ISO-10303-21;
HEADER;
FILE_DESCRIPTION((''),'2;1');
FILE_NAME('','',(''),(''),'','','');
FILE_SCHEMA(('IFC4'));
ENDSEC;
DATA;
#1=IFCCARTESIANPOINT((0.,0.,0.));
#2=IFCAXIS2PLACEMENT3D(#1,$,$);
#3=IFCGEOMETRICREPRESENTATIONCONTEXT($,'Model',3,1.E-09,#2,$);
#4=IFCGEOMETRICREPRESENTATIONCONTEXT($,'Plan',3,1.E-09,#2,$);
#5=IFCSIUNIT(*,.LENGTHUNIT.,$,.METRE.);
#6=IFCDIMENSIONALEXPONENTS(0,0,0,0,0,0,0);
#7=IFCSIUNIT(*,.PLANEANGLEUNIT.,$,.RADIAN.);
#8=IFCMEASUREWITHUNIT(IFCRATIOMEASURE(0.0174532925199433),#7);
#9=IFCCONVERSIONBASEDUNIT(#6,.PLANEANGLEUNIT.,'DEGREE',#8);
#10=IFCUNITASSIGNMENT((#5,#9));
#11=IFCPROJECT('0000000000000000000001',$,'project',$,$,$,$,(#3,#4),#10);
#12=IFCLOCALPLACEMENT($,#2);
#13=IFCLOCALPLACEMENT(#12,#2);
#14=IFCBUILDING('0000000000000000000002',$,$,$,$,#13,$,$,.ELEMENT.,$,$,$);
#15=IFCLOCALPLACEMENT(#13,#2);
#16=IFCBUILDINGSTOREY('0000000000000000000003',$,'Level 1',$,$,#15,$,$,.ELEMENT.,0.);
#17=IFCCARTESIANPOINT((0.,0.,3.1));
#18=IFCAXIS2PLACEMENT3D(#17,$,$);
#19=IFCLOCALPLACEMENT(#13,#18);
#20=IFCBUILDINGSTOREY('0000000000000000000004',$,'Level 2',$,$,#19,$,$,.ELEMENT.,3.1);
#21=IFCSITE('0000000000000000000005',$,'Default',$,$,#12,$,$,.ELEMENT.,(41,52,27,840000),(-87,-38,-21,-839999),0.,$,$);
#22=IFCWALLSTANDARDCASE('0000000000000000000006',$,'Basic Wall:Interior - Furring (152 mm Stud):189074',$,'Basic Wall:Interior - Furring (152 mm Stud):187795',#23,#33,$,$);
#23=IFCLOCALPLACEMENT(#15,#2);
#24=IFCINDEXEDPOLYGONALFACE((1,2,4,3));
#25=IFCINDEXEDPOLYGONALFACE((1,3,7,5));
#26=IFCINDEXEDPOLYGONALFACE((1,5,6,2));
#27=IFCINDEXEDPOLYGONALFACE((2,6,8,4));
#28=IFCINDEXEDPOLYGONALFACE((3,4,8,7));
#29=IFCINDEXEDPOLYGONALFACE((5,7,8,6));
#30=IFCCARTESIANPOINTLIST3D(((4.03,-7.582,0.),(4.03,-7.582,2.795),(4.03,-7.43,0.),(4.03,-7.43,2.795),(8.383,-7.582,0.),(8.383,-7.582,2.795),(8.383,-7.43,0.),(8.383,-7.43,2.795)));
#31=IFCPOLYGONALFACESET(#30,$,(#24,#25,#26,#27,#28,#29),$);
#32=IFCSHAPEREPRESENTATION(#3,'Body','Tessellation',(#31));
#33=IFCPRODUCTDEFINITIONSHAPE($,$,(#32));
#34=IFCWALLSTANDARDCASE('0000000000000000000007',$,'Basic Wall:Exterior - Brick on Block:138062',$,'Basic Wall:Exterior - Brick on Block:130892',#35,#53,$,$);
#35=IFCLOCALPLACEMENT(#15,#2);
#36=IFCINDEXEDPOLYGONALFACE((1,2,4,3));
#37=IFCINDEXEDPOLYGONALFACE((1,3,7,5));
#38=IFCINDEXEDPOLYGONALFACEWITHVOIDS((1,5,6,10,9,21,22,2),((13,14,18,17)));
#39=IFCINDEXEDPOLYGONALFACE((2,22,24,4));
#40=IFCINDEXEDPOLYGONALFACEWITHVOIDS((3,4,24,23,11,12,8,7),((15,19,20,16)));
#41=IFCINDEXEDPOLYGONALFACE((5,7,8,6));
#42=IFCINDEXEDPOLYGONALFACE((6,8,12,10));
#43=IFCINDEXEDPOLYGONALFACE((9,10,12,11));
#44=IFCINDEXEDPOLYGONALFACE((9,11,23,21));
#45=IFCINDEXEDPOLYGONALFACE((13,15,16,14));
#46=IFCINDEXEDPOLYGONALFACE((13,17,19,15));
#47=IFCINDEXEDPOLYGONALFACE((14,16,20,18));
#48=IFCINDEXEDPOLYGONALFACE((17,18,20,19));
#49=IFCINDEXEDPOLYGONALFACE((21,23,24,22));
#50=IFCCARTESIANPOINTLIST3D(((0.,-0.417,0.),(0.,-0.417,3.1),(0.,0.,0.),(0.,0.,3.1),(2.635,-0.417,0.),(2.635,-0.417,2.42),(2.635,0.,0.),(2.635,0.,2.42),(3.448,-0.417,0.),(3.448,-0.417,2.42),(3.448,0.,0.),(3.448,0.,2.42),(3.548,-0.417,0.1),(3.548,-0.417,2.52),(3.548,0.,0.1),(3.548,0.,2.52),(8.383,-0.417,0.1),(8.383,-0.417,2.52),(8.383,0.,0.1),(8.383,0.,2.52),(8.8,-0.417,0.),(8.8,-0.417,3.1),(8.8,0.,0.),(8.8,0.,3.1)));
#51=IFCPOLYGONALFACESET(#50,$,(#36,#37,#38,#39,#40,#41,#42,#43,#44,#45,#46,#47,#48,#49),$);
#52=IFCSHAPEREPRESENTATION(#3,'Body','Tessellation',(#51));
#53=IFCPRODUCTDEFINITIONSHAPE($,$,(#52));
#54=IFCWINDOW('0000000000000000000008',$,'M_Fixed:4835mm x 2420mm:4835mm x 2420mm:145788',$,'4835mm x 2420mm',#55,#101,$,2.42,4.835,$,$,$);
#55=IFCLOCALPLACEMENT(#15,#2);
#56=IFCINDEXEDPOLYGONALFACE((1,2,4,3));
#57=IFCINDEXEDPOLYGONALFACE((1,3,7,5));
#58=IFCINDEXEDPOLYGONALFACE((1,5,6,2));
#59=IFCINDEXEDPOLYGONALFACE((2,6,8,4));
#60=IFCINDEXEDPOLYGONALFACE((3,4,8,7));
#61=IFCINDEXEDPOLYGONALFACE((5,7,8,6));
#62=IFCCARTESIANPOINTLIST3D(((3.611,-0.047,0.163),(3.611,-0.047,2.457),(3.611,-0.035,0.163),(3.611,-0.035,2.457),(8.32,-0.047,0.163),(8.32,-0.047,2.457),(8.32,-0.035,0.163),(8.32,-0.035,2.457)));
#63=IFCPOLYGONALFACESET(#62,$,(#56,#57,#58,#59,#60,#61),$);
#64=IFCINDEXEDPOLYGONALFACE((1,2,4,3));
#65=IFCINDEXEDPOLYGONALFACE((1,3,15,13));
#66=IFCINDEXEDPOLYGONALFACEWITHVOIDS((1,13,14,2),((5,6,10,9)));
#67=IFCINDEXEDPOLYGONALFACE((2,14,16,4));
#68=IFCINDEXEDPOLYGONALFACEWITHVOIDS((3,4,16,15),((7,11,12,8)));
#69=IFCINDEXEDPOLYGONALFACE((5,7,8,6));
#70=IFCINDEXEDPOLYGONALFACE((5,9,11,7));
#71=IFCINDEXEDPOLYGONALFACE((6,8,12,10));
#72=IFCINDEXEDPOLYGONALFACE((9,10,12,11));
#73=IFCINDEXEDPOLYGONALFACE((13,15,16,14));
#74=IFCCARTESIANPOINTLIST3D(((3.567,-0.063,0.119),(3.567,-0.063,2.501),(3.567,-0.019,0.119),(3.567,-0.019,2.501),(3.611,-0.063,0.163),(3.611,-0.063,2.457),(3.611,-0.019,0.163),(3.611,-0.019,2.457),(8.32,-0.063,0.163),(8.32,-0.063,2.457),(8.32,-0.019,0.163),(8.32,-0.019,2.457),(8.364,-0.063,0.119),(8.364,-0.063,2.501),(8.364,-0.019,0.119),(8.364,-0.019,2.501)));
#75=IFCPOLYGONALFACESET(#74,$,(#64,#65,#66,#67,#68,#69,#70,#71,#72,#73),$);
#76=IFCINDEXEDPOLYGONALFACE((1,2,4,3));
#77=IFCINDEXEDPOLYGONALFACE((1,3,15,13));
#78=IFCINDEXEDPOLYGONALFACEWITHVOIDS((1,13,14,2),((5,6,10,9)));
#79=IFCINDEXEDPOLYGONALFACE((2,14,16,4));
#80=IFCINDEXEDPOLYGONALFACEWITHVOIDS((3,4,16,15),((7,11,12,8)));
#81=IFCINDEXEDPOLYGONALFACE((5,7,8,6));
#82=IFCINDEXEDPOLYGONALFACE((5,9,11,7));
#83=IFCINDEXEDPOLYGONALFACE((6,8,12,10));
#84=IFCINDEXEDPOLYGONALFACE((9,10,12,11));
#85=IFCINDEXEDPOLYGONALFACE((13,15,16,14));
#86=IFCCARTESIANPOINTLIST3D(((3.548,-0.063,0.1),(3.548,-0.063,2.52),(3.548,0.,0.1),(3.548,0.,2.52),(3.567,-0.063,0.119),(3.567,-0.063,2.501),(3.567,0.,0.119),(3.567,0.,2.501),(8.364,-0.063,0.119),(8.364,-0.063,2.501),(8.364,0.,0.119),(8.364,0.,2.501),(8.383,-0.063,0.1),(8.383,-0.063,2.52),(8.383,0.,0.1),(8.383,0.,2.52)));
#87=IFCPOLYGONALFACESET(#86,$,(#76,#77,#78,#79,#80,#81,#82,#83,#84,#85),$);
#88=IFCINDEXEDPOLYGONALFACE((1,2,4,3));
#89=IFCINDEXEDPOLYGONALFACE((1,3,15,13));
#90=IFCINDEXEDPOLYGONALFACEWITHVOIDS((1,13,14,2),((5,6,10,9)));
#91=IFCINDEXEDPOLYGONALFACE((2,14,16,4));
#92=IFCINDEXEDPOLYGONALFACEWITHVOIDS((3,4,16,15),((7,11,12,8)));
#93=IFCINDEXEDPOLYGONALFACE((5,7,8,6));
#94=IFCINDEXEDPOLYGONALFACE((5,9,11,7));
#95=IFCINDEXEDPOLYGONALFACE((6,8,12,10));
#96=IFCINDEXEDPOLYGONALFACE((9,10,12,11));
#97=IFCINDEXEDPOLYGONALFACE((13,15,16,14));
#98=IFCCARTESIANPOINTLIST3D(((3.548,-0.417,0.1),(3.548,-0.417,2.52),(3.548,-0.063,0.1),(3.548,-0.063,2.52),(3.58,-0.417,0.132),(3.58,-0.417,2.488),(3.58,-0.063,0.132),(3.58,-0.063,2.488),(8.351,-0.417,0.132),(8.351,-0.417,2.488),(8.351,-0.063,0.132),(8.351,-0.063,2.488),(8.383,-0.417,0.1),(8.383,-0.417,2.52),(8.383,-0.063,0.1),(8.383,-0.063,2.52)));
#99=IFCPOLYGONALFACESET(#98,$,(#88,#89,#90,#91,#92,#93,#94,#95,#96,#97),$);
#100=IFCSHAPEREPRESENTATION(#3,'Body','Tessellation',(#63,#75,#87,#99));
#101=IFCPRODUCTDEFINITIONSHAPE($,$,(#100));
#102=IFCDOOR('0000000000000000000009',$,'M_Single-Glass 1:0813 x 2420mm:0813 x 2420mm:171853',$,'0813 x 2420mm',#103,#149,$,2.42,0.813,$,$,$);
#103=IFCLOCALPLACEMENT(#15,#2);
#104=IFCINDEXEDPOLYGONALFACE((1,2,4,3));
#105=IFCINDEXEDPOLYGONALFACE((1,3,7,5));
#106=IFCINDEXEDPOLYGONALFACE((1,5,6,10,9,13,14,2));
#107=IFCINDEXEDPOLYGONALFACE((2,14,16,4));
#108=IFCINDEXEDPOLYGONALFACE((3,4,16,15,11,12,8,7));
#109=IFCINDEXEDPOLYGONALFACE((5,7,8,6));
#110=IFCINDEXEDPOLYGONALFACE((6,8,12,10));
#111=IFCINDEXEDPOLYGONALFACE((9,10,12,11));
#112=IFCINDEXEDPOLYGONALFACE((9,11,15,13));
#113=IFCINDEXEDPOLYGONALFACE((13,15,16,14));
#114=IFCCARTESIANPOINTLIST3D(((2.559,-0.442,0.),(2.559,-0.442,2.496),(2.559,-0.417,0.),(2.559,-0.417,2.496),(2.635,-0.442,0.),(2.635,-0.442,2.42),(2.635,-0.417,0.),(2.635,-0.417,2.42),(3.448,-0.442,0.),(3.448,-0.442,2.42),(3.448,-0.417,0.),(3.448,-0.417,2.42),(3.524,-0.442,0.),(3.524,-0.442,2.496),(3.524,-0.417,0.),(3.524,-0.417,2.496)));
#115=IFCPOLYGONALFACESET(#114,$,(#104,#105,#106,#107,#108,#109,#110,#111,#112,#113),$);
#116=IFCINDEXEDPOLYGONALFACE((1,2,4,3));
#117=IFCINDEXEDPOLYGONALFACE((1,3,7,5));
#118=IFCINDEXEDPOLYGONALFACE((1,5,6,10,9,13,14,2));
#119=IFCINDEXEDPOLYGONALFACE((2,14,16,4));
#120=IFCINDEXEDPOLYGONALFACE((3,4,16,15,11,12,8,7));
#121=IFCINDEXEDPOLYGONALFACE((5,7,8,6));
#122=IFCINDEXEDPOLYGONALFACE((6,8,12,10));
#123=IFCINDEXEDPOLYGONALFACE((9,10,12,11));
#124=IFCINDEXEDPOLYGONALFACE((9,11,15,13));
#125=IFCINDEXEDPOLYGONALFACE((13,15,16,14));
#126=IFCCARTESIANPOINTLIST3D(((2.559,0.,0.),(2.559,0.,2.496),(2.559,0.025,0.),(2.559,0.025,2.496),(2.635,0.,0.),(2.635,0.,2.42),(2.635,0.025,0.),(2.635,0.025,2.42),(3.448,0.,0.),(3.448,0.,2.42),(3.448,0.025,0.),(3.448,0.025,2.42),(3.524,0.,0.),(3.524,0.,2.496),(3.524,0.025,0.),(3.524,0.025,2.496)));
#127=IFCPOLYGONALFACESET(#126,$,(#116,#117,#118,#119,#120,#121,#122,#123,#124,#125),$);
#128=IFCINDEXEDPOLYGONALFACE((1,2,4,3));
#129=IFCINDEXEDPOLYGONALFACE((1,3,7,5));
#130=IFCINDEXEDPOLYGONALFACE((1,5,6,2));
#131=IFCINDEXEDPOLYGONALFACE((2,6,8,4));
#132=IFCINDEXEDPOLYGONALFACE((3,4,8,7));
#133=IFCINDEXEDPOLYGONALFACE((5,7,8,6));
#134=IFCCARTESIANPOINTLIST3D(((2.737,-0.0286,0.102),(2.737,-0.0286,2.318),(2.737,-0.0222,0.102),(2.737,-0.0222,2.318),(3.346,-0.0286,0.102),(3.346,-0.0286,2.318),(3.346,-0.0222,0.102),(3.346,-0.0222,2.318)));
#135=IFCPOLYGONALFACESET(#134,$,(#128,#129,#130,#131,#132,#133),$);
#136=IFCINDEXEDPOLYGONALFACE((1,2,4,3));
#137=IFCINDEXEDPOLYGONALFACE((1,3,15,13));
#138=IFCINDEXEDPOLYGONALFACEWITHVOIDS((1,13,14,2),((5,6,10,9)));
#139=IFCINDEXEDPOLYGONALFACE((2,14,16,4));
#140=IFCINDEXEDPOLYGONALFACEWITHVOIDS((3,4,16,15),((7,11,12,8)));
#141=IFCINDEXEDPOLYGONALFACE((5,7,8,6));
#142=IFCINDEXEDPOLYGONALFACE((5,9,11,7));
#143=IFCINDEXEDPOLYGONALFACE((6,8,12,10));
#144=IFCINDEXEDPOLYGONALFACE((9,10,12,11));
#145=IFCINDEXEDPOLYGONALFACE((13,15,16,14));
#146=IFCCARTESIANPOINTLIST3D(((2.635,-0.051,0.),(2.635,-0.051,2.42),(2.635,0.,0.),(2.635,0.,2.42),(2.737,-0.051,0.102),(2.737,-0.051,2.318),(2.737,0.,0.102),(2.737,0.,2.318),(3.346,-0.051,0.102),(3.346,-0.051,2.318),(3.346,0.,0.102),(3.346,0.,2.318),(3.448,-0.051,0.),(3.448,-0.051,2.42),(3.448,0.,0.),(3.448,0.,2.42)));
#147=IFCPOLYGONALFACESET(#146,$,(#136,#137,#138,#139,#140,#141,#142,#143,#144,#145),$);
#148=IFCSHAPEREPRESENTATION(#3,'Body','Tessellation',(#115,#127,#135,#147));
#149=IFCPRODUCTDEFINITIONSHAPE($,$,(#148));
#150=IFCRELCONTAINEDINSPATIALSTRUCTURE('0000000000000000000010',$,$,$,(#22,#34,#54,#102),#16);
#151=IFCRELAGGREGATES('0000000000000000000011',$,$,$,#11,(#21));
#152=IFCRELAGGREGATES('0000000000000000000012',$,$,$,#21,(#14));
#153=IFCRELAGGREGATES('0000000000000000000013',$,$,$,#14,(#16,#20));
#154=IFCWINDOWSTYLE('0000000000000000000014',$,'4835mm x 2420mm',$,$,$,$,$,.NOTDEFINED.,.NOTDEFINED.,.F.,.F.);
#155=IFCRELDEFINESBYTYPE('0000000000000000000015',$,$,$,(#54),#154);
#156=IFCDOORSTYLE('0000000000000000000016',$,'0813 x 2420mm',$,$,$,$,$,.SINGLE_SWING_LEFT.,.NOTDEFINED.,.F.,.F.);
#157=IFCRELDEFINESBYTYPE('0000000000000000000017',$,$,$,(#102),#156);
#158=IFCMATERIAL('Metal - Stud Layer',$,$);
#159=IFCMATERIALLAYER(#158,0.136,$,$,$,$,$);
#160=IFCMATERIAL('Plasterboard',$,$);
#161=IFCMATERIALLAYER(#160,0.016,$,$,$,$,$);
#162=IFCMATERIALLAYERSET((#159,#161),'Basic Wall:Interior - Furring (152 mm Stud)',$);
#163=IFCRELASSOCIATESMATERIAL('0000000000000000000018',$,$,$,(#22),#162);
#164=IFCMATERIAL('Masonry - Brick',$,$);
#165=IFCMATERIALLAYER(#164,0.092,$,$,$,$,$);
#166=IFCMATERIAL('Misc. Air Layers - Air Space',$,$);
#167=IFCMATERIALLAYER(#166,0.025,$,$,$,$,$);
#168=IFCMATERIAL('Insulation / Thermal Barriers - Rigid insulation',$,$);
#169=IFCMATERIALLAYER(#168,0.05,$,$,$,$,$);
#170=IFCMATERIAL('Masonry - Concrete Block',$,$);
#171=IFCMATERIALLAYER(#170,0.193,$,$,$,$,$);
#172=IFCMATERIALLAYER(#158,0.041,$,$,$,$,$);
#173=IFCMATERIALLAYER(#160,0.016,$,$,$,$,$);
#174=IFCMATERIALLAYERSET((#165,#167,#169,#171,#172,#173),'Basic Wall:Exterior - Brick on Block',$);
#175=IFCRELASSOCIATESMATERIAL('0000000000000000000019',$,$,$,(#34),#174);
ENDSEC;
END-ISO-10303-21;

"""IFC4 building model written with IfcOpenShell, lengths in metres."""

from ifc_helpers import new_model, entity, si_unit, converted_unit, frame, frame_2d, origin, origin_2d_with_axis, place, context, project, spatial, polyline, rectangle, outline, extrude, clip, bounded_halfspace, source, transform, mapped, material, layer, layer_set, layer_usage, type_object, type_shapes, element, fill, save


model = new_model("IFC4")

# Units and contexts
model_context = context("Model", 3, precision=1e-09, world=origin())
plan_context = context("Plan", 3, precision=1e-09, world=origin())
ifc_project = project(units=[si_unit("LENGTHUNIT", "METRE"), converted_unit("PLANEANGLEUNIT", "DEGREE", entity("IfcRatioMeasure", 0.0174532925199433), si_unit("PLANEANGLEUNIT", "RADIAN"), dimensions=[0, 0, 0, 0, 0, 0, 0])], contexts=[model_context, plan_context])

# Site, building, storey
site_placement = place(None, origin())
site = spatial("IfcSite", under=ifc_project, at=site_placement, Name="Default", CompositionType="ELEMENT", RefLatitude=(41, 52, 27, 840000), RefLongitude=(-87, -38, -21, -839999), RefElevation=0.0)
building_placement = place(site_placement, origin())
building = spatial("IfcBuilding", under=site, at=building_placement, CompositionType="ELEMENT")
storey_1_placement = place(building_placement, origin())
storey_1 = spatial("IfcBuildingStorey", under=building, at=storey_1_placement, Name="Level 1", CompositionType="ELEMENT", Elevation=0.0)

# Wall
ifc_material_1 = material(Name="Metal - Stud Layer")
ifc_layer_1 = layer(ifc_material_1, 0.136)
ifc_material_2 = material(Name="Plasterboard")
ifc_layer_2 = layer(ifc_material_2, 0.016)
ifc_layer_set_1 = layer_set([ifc_layer_1, ifc_layer_2], Name="Basic Wall:Interior - Furring (152 mm Stud)")
ifc_layer_usage_1 = layer_usage(ifc_layer_set_1, "AXIS2", "NEGATIVE", 0.076)
wall_1_placement = place(storey_1_placement, frame((8.383, -7.506, 0.0), z_axis=(0.0, 0.0, 1.0), x_axis=(-1.0, 0.0, 0.0)))
element("IfcWallStandardCase", 1, at=wall_1_placement, inside=storey_1, material=ifc_layer_usage_1, Name="Basic Wall:Interior - Furring (152 mm Stud):189074", ObjectType="Basic Wall:Interior - Furring (152 mm Stud):187795", context=model_context, shape_type="Clipping", body=[
    clip(extrude(rectangle(XDim=4.353, YDim=0.152, at=frame_2d((2.1765, 0.0), x_axis=(-1.0, 0.0))), origin(), (0.0, 0.0, 1.0), 2.795), bounded_halfspace(frame((0.0, -0.076, 2.795), z_axis=(0.0, 0.0, -1.0), x_axis=(0.0, 1.0, 0.0)), True, frame((0.0, -0.076, 2.795)), polyline([(0.0, 0.0), (3.708, 0.0), (3.708, 0.152), (0.0, 0.152), (0.0, 0.0)]))),
])
ifc_material_3 = material(Name="Masonry - Concrete Block")
ifc_material_4 = material(Name="Misc. Air Layers - Air Space")

# Wall, openings, window, door
ifc_material_5 = material(Name="Masonry - Brick")
ifc_layer_3 = layer(ifc_material_5, 0.092)
ifc_layer_4 = layer(ifc_material_4, 0.025)
ifc_material_6 = material(Name="Insulation / Thermal Barriers - Rigid insulation")
ifc_layer_5 = layer(ifc_material_6, 0.05)
ifc_layer_6 = layer(ifc_material_3, 0.193)
ifc_layer_7 = layer(ifc_material_1, 0.041)
ifc_layer_8 = layer(ifc_material_2, 0.016)
ifc_layer_set_2 = layer_set([ifc_layer_3, ifc_layer_4, ifc_layer_5, ifc_layer_6, ifc_layer_7, ifc_layer_8], Name="Basic Wall:Exterior - Brick on Block")
ifc_layer_usage_2 = layer_usage(ifc_layer_set_2, "AXIS2", "NEGATIVE", 0.2085)
wall_2_placement = place(storey_1_placement, frame((0.0, -0.2085, 0.0)))
wall_2 = element("IfcWallStandardCase", 2, at=wall_2_placement, inside=storey_1, material=ifc_layer_usage_2, Name="Basic Wall:Exterior - Brick on Block:138062", ObjectType="Basic Wall:Exterior - Brick on Block:130892", context=model_context, shape_type="SweptSolid", body=[
    extrude(rectangle(XDim=8.8, YDim=0.417, at=frame_2d((4.4, 0.0), x_axis=(-1.0, 0.0))), origin(), (0.0, 0.0, 1.0), 3.1),
])
opening_1_placement = place(wall_2_placement, frame((2.635, -0.2085, 0.0)))
opening_1 = element("IfcOpeningElement", 3, at=opening_1_placement, cuts=wall_2, ObjectType="Opening", context=model_context, shape_type="SweptSolid", body=[
    extrude(rectangle(XDim=0.813, YDim=2.42, at=frame_2d((1.21, 0.4065), x_axis=(0.0, -1.0))), frame((0.0, 0.0, 0.0), z_axis=(0.0, 1.0, 0.0), x_axis=(0.0, 0.0, 1.0)), (0.0, 0.0, 1.0), 0.417),
])
opening_2_placement = place(wall_2_placement, frame((3.548, -0.2085, 0.1)))
opening_2 = element("IfcOpeningElement", 4, at=opening_2_placement, cuts=wall_2, ObjectType="Opening", context=model_context, shape_type="SweptSolid", body=[
    extrude(rectangle(XDim=2.42, YDim=4.835, at=frame_2d((1.21, 2.4175), x_axis=(1.0, 0.0))), frame((0.0, 0.0, 0.0), z_axis=(0.0, 1.0, 0.0), x_axis=(0.0, 0.0, 1.0)), (0.0, 0.0, 1.0), 0.417),
])
window_style_1 = type_object("IfcWindowStyle", Name="4835mm x 2420mm", ConstructionType="NOTDEFINED", OperationType="NOTDEFINED", ParameterTakesPrecedence=False, Sizeable=False)
shared_shape_1 = source(origin(), model_context, "Body", "SweptSolid", [
    extrude(rectangle(XDim=0.012, YDim=4.709, at=origin_2d_with_axis()), frame((2.4175, 0.376, 0.063), z_axis=(0.0, 0.0, 1.0), x_axis=(0.0, -1.0, 0.0)), (0.0, 0.0, 1.0), 2.294),
    extrude(outline(polyline([(-2.3985, -1.191), (2.3985, -1.191), (2.3985, 1.191), (-2.3985, 1.191), (-2.3985, -1.191)]), holes=[polyline([(-2.3545, -1.147), (-2.3545, 1.147), (2.3545, 1.147), (2.3545, -1.147), (-2.3545, -1.147)])]), frame((2.4175, 0.354, 1.21), z_axis=(0.0, 1.0, 0.0), x_axis=(1.0, 0.0, 0.0)), (0.0, 0.0, 1.0), 0.044),
    extrude(outline(polyline([(-2.4175, -1.21), (2.4175, -1.21), (2.4175, 1.21), (-2.4175, 1.21), (-2.4175, -1.21)]), holes=[polyline([(-2.3985, -1.191), (-2.3985, 1.191), (2.3985, 1.191), (2.3985, -1.191), (-2.3985, -1.191)])]), frame((2.4175, 0.354, 1.21), z_axis=(0.0, 1.0, 0.0), x_axis=(1.0, 0.0, 0.0)), (0.0, 0.0, 1.0), 0.063),
    extrude(outline(polyline([(-2.4175, -1.21), (2.4175, -1.21), (2.4175, 1.21), (-2.4175, 1.21), (-2.4175, -1.21)]), holes=[polyline([(-2.3855, -1.178), (-2.3855, 1.178), (2.3855, 1.178), (2.3855, -1.178), (-2.3855, -1.178)])]), frame((2.4175, 0.0, 1.21), z_axis=(0.0, 1.0, 0.0), x_axis=(1.0, 0.0, 0.0)), (0.0, 0.0, 1.0), 0.354),
])
type_shapes(window_style_1, [shared_shape_1])
window_1_placement = place(opening_2_placement, origin())
window_1 = element("IfcWindow", 5, at=window_1_placement, inside=storey_1, type_object=window_style_1, Name="M_Fixed:4835mm x 2420mm:4835mm x 2420mm:145788", ObjectType="4835mm x 2420mm", OverallHeight=2.42, OverallWidth=4.835, context=model_context, shape_type="MappedRepresentation", body=[
    mapped(shared_shape_1, transform((0.0, 0.0, 0.0), scale=1.0)),
])
fill(opening_2, window_1)
door_style_1 = type_object("IfcDoorStyle", Name="0813 x 2420mm", ConstructionType="NOTDEFINED", OperationType="SINGLE_SWING_LEFT", ParameterTakesPrecedence=False, Sizeable=False)
shared_shape_2 = source(origin(), model_context, "Body", "SweptSolid", [
    extrude(outline(polyline([(-0.4065, -1.191), (-0.4065, 1.229), (-0.4825, 1.229), (-0.4825, -1.267), (0.4825, -1.267), (0.4825, 1.229), (0.4065, 1.229), (0.4065, -1.191), (-0.4065, -1.191)])), frame((0.4065, 0.0, 1.229), z_axis=(0.0, 1.0, 0.0), x_axis=(1.0, 0.0, 0.0)), (0.0, 0.0, -1.0), 0.025),
    extrude(outline(polyline([(-0.4065, -1.191), (-0.4065, 1.229), (-0.4825, 1.229), (-0.4825, -1.267), (0.4825, -1.267), (0.4825, 1.229), (0.4065, 1.229), (0.4065, -1.191), (-0.4065, -1.191)])), frame((0.4065, 0.442, 1.229), z_axis=(0.0, 1.0, 0.0), x_axis=(1.0, 0.0, 0.0)), (0.0, 0.0, -1.0), 0.025),
    extrude(rectangle(XDim=0.609, YDim=0.0064, at=origin_2d_with_axis()), frame((0.4065, 0.3916, 0.102)), (0.0, 0.0, 1.0), 2.216),
    extrude(outline(polyline([(-1.21, -0.4065), (1.21, -0.4065), (1.21, 0.4065), (-1.21, 0.4065), (-1.21, -0.4065)]), holes=[polyline([(-1.108, 0.3045), (1.108, 0.3045), (1.108, -0.3045), (-1.108, -0.3045), (-1.108, 0.3045)])]), frame((0.4065, 0.417, 1.21), z_axis=(0.0, -1.0, 0.0), x_axis=(0.0, 0.0, -1.0)), (0.0, 0.0, 1.0), 0.051),
])
type_shapes(door_style_1, [shared_shape_2])
door_1_placement = place(opening_1_placement, origin())
door_1 = element("IfcDoor", 6, at=door_1_placement, inside=storey_1, type_object=door_style_1, Name="M_Single-Glass 1:0813 x 2420mm:0813 x 2420mm:171853", ObjectType="0813 x 2420mm", OverallHeight=2.42, OverallWidth=0.813, context=model_context, shape_type="MappedRepresentation", body=[
    mapped(shared_shape_2, transform((0.0, 0.0, 0.0), scale=1.0)),
])
fill(opening_1, door_1)

# Shared definitions
storey_2_placement = place(building_placement, frame((0.0, 0.0, 3.1)))
storey_2 = spatial("IfcBuildingStorey", under=building, at=storey_2_placement, Name="Level 2", CompositionType="ELEMENT", Elevation=3.1)

save(model, "model.ifc")
